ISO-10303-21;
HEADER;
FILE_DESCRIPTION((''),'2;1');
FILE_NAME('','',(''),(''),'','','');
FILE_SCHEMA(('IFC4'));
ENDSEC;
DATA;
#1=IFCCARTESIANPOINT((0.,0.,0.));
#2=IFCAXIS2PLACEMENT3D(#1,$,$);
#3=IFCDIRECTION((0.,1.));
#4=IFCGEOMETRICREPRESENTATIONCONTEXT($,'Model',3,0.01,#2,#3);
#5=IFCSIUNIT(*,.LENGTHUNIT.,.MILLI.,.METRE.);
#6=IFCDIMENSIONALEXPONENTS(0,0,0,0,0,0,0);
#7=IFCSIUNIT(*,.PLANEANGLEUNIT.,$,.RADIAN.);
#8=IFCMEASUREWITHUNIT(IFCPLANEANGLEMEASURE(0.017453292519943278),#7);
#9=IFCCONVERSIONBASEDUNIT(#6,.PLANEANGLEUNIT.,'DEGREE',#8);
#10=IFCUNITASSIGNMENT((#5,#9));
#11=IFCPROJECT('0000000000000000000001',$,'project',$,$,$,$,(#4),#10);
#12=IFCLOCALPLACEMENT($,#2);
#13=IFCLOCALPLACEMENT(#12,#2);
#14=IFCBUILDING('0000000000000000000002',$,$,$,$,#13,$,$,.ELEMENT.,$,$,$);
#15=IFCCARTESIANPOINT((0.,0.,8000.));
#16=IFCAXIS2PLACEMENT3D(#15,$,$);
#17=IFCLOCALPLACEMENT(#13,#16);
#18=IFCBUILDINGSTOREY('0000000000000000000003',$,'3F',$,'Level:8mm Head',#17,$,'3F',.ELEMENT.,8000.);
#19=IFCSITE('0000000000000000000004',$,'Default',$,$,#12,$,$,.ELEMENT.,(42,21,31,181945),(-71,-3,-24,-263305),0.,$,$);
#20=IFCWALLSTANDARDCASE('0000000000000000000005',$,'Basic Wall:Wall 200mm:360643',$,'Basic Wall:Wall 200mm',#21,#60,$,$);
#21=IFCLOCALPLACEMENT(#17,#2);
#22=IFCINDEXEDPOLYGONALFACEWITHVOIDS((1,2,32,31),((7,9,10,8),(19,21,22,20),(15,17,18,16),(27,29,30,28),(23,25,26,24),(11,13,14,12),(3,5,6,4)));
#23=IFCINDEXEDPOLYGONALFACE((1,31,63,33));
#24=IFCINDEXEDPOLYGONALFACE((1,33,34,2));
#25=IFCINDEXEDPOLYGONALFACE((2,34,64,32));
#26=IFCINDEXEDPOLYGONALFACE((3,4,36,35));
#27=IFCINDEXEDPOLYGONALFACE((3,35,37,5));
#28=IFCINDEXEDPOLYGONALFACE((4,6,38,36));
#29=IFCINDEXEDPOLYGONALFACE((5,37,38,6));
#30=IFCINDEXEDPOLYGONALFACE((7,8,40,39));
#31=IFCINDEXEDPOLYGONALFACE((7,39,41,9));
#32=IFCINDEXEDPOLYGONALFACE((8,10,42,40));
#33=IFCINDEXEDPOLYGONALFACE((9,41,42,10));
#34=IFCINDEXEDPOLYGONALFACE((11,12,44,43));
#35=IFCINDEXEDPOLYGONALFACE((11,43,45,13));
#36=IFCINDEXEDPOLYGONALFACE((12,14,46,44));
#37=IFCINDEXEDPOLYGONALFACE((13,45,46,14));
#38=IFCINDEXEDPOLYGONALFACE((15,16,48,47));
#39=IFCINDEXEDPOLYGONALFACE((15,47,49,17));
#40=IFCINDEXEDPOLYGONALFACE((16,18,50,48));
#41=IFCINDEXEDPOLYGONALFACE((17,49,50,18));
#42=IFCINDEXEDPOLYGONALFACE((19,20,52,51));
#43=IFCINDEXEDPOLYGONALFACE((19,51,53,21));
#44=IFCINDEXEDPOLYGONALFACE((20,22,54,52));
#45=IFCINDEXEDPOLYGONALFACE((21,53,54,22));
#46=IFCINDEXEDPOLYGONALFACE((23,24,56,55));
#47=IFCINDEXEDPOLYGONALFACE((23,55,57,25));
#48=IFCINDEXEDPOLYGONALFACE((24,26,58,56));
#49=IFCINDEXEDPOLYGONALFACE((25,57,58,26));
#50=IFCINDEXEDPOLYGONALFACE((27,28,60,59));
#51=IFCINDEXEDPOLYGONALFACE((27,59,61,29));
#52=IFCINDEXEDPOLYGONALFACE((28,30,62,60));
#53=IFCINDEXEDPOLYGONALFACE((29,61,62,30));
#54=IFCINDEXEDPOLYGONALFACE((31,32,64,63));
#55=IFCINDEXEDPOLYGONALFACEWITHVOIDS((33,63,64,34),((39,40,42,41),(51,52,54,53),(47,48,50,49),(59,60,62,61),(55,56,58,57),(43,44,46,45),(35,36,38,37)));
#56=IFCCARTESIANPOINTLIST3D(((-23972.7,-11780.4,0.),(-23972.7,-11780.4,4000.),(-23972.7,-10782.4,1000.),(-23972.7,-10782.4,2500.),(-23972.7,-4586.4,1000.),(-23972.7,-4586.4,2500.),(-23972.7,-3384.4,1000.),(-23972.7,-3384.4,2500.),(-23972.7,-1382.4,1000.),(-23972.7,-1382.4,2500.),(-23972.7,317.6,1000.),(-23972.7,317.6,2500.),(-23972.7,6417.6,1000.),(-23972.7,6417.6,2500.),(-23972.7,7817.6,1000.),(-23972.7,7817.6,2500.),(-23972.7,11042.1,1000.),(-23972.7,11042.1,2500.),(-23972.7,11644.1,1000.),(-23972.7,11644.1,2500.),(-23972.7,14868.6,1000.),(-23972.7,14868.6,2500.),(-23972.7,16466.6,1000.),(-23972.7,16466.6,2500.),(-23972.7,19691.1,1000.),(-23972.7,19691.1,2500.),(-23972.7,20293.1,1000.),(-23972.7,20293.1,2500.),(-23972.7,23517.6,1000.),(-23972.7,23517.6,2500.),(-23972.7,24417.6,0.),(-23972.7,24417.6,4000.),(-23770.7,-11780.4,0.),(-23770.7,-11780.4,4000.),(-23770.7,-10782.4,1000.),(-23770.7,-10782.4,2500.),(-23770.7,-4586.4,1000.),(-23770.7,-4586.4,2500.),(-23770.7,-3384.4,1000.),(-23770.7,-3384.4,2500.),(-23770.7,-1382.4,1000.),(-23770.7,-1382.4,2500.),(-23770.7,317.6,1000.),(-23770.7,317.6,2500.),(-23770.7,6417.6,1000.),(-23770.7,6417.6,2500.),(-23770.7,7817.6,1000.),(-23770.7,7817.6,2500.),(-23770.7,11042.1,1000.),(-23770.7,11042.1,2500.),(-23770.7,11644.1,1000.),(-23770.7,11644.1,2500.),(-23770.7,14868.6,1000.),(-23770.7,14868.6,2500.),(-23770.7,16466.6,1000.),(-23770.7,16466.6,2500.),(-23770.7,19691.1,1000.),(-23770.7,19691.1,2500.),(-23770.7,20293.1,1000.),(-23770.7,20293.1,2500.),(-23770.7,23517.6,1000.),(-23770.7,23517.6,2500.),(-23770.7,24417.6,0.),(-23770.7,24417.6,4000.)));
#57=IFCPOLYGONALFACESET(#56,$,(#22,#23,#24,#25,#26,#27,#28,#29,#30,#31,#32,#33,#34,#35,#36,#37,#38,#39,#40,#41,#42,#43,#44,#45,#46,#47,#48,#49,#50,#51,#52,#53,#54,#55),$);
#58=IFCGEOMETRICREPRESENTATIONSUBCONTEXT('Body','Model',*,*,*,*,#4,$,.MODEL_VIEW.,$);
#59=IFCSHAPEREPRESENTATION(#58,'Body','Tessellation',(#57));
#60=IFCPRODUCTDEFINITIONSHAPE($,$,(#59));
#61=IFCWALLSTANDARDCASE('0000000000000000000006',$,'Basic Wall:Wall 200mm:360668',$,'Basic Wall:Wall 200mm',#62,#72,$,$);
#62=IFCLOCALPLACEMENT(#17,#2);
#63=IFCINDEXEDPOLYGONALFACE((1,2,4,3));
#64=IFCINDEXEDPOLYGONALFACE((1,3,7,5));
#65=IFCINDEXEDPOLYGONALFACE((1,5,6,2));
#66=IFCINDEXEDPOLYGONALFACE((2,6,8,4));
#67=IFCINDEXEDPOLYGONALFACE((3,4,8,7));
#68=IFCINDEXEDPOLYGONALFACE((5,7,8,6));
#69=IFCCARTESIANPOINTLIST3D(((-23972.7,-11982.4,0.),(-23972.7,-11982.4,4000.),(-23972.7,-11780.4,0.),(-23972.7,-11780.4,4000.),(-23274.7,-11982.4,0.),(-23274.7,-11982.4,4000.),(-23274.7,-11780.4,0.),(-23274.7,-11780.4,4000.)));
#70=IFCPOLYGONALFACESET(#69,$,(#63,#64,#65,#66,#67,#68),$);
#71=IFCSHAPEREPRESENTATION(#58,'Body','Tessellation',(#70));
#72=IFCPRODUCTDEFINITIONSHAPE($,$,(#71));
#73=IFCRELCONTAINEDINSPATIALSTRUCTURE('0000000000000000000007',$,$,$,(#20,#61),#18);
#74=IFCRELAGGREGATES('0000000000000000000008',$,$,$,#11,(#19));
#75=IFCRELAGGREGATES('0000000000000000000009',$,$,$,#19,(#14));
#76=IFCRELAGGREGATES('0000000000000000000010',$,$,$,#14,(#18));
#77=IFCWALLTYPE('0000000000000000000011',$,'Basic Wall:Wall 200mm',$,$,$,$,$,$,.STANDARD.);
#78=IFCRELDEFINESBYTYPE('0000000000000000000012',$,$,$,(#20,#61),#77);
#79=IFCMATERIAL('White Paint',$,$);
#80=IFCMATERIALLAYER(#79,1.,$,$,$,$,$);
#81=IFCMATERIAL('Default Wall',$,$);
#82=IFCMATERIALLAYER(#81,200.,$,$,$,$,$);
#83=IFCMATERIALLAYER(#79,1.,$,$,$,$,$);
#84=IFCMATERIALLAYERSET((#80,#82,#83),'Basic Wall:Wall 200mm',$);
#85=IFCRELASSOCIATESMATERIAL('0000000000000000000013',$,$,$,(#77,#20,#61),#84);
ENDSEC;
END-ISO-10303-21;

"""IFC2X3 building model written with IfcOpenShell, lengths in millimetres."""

from ifc_helpers import new_model, entity, si_unit, converted_unit, direction, frame, frame_2d, origin, origin_2d_with_axis, place, context, subcontext, project, spatial, rectangle, extrude, material, layer, layer_set, layer_usage, type_object, element, save


model = new_model("IFC2X3")

# Units and contexts
model_context = context("Model", 3, precision=0.01, world=origin(), true_north=direction((0.0, 1.0)))
body_context = subcontext(model_context, "Body", "Model", "MODEL_VIEW")
ifc_project = project(units=[si_unit("LENGTHUNIT", "METRE", prefix="MILLI"), converted_unit("PLANEANGLEUNIT", "DEGREE", entity("IfcPlaneAngleMeasure", 0.017453292519943278), si_unit("PLANEANGLEUNIT", "RADIAN"), dimensions=[0, 0, 0, 0, 0, 0, 0])], contexts=[model_context])

# Site, building, storey
site_placement = place(None, origin())
site = spatial("IfcSite", under=ifc_project, at=site_placement, Name="Default", CompositionType="ELEMENT", RefLatitude=(42, 21, 31, 181945), RefLongitude=(-71, -3, -24, -263305), RefElevation=0.0)
building_placement = place(site_placement, origin())
building = spatial("IfcBuilding", under=site, at=building_placement, CompositionType="ELEMENT")
storey_placement = place(building_placement, frame((0.0, 0.0, 8000.0)))
storey = spatial("IfcBuildingStorey", under=building, at=storey_placement, Name="3F", ObjectType="Level:8mm Head", LongName="3F", CompositionType="ELEMENT", Elevation=8000.0)

# Wall, openings
ifc_material_1 = material(Name="White Paint")
ifc_layer_1 = layer(ifc_material_1, 1.0)
ifc_material_2 = material(Name="Default Wall")
ifc_layer_2 = layer(ifc_material_2, 200.0)
ifc_layer_3 = layer(ifc_material_1, 1.0)
ifc_layer_set_1 = layer_set([ifc_layer_1, ifc_layer_2, ifc_layer_3], Name="Basic Wall:Wall 200mm")
ifc_layer_usage_1 = layer_usage(ifc_layer_set_1, "AXIS2", "NEGATIVE", 101.0)
wall_type = type_object("IfcWallType", Name="Basic Wall:Wall 200mm", PredefinedType="STANDARD", material=ifc_layer_set_1)
wall_1_placement = place(storey_placement, frame((-23871.7, -11780.4, 0.0), z_axis=(0.0, 0.0, 1.0), x_axis=(0.0, 1.0, 0.0)))
wall_1 = element("IfcWallStandardCase", 1, at=wall_1_placement, inside=storey, type_object=wall_type, material=ifc_layer_usage_1, Name="Basic Wall:Wall 200mm:360643", ObjectType="Basic Wall:Wall 200mm", context=body_context, shape_type="SweptSolid", body=[
    extrude(rectangle(XDim=36198.0, YDim=202.0, at=frame_2d((18099.0, 0.0), x_axis=(-1.0, 0.0))), origin(), (0.0, 0.0, 1.0), 4000.0),
])
opening_1_placement = place(wall_1_placement, origin())
element("IfcOpeningElement", 2, at=opening_1_placement, cuts=wall_1, ObjectType="Opening", context=body_context, shape_type="SweptSolid", body=[
    extrude(rectangle(XDim=1500.0, YDim=3224.5, at=origin_2d_with_axis()), frame((33685.7, 101.0, 1750.0), z_axis=(0.0, -1.0, 0.0), x_axis=(0.0, 0.0, -1.0)), (0.0, 0.0, 1.0), 202.0),
])
opening_2_placement = place(wall_1_placement, origin())
element("IfcOpeningElement", 3, at=opening_2_placement, cuts=wall_1, ObjectType="Opening", context=body_context, shape_type="SweptSolid", body=[
    extrude(rectangle(XDim=1500.0, YDim=3224.5, at=frame_2d((0.0, 0.0), x_axis=(1.0, 0.0))), frame((29859.2, 101.0, 1750.0), z_axis=(0.0, 1.0, 0.0), x_axis=(0.0, 0.0, -1.0)), (0.0, 0.0, -1.0), 202.0),
])
opening_3_placement = place(wall_1_placement, origin())
element("IfcOpeningElement", 4, at=opening_3_placement, cuts=wall_1, ObjectType="Opening", context=body_context, shape_type="SweptSolid", body=[
    extrude(rectangle(XDim=1500.0, YDim=3224.5, at=origin_2d_with_axis()), frame((25036.7, 101.0, 1750.0), z_axis=(0.0, 1.0, 0.0), x_axis=(0.0, 0.0, -1.0)), (0.0, 0.0, -1.0), 202.0),
])
opening_4_placement = place(wall_1_placement, origin())
element("IfcOpeningElement", 5, at=opening_4_placement, cuts=wall_1, ObjectType="Opening", context=body_context, shape_type="SweptSolid", body=[
    extrude(rectangle(XDim=1500.0, YDim=3224.5, at=origin_2d_with_axis()), frame((21210.2, 101.0, 1750.0), z_axis=(0.0, 1.0, 0.0), x_axis=(0.0, 0.0, -1.0)), (0.0, 0.0, -1.0), 202.0),
])
opening_5_placement = place(wall_1_placement, origin())
element("IfcOpeningElement", 6, at=opening_5_placement, cuts=wall_1, ObjectType="Opening", context=body_context, shape_type="SweptSolid", body=[
    extrude(rectangle(XDim=1500.0, YDim=6100.0, at=origin_2d_with_axis()), frame((15148.0, 101.0, 1750.0), z_axis=(0.0, -1.0, 0.0), x_axis=(0.0, 0.0, -1.0)), (0.0, 0.0, 1.0), 202.0),
])
opening_6_placement = place(wall_1_placement, origin())
element("IfcOpeningElement", 7, at=opening_6_placement, cuts=wall_1, ObjectType="Opening", context=body_context, shape_type="SweptSolid", body=[
    extrude(rectangle(XDim=1500.0, YDim=2002.0, at=origin_2d_with_axis()), frame((9397.0, 101.0, 1750.0), z_axis=(0.0, -1.0, 0.0), x_axis=(0.0, 0.0, -1.0)), (0.0, 0.0, 1.0), 202.0),
])
opening_7_placement = place(wall_1_placement, origin())
element("IfcOpeningElement", 8, at=opening_7_placement, cuts=wall_1, ObjectType="Opening", context=body_context, shape_type="SweptSolid", body=[
    extrude(rectangle(XDim=1500.0, YDim=6196.0, at=origin_2d_with_axis()), frame((4096.0, 101.0, 1750.0), z_axis=(0.0, 1.0, 0.0), x_axis=(0.0, 0.0, -1.0)), (0.0, 0.0, -1.0), 202.0),
])

# Wall
ifc_layer_usage_2 = layer_usage(ifc_layer_set_1, "AXIS2", "NEGATIVE", 101.0)
wall_2_placement = place(storey_placement, frame((-23274.7, -11881.4, 0.0), z_axis=(0.0, 0.0, 1.0), x_axis=(-1.0, 0.0, 0.0)))
element("IfcWallStandardCase", 9, at=wall_2_placement, inside=storey, type_object=wall_type, material=ifc_layer_usage_2, Name="Basic Wall:Wall 200mm:360668", ObjectType="Basic Wall:Wall 200mm", context=body_context, shape_type="SweptSolid", body=[
    extrude(rectangle(XDim=698.0, YDim=202.0, at=frame_2d((349.0, 0.0), x_axis=(-1.0, 0.0))), origin(), (0.0, 0.0, 1.0), 4000.0),
])

save(model, "model.ifc")
